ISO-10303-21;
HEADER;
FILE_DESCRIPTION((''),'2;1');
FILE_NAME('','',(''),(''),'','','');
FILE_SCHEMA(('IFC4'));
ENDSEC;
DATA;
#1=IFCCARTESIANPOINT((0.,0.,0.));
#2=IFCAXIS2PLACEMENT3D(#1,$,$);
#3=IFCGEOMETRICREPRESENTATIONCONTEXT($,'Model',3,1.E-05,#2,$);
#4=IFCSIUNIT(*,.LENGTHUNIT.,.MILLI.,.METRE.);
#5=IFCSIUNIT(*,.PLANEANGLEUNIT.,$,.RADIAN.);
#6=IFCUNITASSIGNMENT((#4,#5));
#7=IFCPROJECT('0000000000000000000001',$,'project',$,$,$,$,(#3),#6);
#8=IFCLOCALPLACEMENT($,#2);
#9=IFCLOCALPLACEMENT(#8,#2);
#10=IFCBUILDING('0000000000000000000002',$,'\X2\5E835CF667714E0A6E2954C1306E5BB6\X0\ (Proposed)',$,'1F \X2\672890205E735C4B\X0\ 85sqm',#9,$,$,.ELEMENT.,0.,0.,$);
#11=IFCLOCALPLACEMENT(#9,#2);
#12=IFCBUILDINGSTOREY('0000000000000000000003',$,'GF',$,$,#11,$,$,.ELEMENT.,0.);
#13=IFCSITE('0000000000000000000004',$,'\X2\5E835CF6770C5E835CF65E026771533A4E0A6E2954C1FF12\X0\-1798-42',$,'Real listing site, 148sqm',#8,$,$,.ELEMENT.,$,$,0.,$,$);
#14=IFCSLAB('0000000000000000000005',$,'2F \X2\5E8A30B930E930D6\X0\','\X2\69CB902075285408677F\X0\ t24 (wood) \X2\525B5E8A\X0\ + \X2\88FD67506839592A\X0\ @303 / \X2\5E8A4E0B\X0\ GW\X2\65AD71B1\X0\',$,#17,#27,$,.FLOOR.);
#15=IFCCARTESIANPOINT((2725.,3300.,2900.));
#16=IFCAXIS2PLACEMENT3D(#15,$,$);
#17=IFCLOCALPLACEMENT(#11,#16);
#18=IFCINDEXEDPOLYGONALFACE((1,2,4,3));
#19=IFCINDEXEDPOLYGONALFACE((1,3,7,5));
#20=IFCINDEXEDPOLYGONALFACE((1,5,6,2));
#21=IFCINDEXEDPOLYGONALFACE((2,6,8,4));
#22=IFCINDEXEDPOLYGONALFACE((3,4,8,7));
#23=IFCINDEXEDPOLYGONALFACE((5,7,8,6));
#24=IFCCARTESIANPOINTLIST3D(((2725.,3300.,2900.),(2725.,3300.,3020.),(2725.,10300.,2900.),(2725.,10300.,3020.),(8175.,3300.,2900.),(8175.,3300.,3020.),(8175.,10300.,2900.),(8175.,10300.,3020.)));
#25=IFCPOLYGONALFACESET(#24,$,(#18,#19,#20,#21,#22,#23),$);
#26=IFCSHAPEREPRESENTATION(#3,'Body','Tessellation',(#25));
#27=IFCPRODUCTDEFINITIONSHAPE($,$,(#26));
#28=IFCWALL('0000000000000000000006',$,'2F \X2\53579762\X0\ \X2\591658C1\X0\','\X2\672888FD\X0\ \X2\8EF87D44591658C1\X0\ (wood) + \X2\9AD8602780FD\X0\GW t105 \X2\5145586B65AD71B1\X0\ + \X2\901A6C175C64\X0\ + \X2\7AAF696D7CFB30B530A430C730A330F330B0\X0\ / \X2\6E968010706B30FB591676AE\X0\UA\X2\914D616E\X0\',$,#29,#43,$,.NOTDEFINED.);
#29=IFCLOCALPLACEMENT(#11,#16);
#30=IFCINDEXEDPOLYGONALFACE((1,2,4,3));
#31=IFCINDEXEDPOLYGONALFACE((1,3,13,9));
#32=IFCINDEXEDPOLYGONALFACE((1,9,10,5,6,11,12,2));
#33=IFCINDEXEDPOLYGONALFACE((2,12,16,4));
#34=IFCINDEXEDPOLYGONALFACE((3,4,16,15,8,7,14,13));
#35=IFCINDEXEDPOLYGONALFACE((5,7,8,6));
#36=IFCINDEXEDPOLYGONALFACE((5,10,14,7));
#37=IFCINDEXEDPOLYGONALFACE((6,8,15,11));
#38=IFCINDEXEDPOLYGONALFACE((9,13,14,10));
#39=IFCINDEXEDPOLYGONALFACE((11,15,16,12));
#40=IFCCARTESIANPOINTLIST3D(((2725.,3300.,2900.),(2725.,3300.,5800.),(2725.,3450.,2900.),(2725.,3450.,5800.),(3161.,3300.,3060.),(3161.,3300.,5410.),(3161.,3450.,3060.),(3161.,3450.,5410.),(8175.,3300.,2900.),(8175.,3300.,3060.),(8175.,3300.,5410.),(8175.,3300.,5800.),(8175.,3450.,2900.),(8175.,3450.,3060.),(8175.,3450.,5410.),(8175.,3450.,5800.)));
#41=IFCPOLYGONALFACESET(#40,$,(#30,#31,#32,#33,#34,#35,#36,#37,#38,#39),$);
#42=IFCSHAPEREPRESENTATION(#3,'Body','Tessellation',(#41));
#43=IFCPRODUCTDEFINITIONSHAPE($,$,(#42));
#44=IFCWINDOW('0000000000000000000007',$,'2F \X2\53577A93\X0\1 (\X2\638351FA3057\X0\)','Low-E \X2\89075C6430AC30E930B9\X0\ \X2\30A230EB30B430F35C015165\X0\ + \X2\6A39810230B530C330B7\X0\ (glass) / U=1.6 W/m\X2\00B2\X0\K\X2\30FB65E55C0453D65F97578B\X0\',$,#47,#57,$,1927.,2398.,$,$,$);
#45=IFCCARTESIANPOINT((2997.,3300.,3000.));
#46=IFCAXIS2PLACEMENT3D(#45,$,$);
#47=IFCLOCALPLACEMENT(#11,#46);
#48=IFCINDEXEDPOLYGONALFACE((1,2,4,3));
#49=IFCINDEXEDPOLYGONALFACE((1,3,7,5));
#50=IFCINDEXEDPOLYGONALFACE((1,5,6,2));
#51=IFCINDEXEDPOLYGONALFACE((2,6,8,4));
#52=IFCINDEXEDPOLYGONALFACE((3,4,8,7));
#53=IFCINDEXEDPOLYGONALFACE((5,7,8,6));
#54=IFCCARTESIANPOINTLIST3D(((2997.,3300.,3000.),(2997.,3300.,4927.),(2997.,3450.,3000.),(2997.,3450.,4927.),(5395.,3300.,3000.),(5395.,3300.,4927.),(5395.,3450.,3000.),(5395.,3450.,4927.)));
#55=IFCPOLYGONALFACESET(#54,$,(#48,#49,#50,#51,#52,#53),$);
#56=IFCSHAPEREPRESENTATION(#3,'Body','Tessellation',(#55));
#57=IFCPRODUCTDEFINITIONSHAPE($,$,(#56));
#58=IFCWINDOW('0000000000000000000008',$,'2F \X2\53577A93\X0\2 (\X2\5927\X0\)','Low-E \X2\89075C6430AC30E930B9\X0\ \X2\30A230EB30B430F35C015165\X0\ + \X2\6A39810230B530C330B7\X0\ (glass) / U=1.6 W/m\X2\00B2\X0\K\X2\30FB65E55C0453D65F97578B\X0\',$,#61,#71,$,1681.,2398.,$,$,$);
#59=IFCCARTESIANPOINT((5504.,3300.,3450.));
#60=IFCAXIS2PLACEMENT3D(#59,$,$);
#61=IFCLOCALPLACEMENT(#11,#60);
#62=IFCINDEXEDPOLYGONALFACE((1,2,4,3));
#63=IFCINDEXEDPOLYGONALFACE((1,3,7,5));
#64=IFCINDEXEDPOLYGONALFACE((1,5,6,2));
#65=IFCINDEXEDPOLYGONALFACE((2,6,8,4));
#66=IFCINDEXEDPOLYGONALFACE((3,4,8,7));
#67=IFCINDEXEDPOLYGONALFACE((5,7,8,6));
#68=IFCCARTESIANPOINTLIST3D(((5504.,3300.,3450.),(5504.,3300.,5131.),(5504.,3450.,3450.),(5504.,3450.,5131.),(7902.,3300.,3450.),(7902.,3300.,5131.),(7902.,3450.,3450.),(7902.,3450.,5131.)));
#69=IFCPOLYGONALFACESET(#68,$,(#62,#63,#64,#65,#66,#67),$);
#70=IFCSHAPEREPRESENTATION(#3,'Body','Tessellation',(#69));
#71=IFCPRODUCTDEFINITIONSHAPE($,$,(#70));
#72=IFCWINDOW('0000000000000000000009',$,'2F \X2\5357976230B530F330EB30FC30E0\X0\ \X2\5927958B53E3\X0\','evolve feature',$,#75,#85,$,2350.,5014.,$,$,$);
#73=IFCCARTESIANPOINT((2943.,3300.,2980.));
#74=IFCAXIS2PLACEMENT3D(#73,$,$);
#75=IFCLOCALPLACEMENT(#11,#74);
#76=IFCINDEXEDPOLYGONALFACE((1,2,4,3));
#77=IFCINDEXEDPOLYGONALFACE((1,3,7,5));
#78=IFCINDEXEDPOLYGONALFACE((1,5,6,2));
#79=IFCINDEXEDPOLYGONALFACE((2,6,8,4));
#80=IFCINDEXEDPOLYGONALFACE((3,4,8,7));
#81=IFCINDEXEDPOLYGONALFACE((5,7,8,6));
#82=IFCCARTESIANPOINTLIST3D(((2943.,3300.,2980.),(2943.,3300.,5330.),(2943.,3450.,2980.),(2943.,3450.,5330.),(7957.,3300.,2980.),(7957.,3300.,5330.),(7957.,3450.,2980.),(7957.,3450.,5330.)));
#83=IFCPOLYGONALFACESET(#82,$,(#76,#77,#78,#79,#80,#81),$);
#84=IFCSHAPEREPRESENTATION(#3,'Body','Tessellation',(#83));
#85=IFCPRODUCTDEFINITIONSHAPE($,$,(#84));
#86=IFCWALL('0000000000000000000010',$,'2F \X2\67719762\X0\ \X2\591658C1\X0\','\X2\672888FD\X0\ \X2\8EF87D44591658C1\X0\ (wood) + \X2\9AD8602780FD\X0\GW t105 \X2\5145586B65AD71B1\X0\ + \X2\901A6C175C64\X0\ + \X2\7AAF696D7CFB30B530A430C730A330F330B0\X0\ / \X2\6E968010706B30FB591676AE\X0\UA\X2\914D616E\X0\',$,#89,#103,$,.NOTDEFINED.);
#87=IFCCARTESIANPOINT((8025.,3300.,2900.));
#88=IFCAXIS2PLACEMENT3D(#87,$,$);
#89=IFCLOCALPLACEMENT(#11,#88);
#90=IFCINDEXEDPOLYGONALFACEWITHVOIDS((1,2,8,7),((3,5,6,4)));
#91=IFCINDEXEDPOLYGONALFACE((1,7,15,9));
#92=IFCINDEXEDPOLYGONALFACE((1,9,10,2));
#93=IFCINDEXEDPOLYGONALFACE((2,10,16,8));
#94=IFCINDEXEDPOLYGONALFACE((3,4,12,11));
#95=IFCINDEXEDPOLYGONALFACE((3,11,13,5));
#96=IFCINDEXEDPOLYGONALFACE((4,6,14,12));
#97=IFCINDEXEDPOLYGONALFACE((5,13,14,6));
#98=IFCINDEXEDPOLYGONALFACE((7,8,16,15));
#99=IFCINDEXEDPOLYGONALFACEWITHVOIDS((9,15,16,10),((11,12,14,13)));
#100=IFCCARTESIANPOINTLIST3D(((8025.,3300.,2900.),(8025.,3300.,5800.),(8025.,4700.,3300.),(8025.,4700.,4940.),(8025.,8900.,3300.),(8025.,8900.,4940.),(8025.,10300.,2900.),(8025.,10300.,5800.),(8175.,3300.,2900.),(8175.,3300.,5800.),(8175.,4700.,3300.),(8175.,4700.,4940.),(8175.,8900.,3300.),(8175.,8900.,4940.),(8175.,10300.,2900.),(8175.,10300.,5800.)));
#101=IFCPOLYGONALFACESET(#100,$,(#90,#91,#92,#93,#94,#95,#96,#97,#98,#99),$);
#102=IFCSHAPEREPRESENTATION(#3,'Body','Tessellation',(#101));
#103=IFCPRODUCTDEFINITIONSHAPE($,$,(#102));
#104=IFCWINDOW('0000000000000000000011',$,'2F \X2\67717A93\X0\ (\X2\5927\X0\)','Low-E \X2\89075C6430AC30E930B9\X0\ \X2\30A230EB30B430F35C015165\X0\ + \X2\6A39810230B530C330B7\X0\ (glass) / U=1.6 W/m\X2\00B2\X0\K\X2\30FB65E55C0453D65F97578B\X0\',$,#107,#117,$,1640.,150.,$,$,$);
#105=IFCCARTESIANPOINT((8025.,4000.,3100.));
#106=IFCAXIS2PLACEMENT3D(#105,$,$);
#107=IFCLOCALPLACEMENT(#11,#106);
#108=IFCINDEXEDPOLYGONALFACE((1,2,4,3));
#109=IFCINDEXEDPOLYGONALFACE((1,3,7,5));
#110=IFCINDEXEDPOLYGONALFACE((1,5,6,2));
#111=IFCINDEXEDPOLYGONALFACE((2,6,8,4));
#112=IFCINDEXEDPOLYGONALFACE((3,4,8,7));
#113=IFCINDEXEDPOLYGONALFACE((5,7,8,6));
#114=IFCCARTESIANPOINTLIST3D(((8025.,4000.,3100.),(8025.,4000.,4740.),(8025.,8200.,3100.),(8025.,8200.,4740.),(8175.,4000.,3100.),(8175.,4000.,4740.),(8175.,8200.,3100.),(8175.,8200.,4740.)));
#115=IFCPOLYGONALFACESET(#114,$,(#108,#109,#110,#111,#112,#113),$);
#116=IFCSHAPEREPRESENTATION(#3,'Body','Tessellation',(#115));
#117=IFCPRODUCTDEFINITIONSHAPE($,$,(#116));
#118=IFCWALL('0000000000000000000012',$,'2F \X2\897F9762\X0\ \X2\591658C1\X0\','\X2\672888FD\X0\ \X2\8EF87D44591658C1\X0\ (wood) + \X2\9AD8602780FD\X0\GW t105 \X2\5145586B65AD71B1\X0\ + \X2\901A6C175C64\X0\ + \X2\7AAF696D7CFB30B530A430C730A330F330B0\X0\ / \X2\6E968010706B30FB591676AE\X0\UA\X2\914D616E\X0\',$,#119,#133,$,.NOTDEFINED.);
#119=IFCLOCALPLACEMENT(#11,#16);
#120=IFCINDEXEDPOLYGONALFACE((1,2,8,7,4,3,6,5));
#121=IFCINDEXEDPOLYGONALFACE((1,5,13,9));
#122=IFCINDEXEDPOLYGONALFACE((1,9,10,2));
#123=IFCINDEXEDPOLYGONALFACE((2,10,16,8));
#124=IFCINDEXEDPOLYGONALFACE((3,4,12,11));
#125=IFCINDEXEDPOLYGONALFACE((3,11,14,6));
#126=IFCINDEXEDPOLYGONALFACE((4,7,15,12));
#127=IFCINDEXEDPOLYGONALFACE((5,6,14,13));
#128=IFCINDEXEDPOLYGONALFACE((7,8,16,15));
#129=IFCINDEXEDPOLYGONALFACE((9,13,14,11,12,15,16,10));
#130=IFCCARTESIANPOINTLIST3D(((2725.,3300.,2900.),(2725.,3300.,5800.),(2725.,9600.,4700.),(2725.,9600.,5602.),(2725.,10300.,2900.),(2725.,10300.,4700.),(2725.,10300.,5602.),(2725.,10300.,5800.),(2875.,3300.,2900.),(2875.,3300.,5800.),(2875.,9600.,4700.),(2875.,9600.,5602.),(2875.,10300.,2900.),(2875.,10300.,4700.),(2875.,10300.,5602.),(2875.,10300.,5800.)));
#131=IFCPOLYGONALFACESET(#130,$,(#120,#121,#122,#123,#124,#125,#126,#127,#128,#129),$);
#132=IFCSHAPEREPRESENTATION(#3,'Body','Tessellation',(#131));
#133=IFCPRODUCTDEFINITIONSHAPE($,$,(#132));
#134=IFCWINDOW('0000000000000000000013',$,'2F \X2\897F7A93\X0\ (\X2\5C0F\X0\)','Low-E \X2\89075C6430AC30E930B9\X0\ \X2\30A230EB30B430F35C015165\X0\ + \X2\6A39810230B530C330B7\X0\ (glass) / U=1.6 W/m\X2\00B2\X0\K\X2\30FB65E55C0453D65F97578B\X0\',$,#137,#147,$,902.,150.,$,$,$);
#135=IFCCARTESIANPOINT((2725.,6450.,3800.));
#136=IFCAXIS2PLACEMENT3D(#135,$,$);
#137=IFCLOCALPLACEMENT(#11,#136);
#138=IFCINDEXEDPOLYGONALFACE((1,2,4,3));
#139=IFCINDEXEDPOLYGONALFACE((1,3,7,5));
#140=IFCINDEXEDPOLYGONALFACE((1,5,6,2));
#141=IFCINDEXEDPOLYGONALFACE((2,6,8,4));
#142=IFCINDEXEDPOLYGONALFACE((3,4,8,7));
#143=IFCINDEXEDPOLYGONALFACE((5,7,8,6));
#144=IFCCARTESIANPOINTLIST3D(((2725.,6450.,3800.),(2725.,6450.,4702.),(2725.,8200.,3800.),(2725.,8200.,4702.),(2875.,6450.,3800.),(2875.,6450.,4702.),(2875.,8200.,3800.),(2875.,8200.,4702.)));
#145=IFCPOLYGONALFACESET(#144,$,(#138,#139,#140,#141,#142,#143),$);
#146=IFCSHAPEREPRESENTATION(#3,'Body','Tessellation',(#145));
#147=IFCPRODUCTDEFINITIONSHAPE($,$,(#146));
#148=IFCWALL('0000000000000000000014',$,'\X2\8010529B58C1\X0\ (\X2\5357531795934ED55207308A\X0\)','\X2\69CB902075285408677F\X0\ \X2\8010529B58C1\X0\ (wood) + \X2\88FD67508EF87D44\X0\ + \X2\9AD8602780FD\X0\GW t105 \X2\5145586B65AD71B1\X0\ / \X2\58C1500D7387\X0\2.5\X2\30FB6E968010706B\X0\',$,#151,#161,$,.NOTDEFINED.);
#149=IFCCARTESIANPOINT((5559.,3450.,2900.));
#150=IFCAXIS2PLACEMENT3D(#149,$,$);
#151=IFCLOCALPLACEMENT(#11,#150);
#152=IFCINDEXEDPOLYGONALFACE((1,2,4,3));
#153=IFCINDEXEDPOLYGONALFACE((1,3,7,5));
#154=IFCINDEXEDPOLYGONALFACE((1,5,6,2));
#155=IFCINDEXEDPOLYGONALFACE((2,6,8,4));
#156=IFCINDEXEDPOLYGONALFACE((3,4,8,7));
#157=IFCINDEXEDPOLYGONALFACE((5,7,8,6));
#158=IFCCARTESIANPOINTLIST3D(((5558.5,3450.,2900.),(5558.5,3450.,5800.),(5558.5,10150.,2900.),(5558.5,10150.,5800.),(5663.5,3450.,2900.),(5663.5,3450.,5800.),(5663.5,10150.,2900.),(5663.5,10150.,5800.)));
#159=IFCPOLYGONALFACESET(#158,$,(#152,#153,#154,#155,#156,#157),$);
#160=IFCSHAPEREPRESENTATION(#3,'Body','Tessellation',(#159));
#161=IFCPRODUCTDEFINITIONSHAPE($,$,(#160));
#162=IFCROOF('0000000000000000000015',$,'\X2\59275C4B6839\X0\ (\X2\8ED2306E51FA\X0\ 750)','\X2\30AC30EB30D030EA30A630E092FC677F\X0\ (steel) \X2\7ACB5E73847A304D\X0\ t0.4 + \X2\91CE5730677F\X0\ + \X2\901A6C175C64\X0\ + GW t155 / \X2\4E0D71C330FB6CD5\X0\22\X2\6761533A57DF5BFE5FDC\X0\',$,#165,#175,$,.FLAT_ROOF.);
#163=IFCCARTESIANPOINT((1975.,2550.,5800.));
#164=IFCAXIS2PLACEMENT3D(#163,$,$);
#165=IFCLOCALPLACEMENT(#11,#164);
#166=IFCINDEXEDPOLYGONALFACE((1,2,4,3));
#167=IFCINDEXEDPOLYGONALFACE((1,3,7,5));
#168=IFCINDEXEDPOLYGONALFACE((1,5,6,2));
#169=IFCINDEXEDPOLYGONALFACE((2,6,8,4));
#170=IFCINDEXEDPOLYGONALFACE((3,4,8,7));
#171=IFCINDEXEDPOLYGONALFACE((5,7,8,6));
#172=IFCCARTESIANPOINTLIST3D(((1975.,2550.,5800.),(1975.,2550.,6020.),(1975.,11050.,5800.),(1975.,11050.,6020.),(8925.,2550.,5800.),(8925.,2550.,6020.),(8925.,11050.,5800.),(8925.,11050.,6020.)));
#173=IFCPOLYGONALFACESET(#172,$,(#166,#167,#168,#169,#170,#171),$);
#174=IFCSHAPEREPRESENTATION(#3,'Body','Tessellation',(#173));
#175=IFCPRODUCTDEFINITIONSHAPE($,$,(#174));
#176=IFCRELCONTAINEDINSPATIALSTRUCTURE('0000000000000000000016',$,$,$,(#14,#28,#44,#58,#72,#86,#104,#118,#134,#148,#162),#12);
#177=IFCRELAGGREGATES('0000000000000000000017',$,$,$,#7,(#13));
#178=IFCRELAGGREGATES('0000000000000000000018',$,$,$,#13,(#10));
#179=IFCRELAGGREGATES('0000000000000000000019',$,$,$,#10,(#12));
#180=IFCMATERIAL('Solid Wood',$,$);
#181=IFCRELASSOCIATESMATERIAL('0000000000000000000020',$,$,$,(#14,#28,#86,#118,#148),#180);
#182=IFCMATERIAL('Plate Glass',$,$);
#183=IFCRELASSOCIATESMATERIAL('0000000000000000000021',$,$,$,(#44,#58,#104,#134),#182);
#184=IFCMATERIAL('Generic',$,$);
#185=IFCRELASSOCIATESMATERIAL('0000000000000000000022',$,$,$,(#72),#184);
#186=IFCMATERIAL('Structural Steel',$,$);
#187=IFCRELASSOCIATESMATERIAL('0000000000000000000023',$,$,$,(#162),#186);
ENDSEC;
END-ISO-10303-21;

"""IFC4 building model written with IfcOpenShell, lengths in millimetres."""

from ifc_helpers import new_model, si_unit, frame, frame_2d, origin, place, context, project, spatial, rectangle, extrude, material, element, fill, save


model = new_model("IFC4")

# Units and contexts
model_context = context("Model", 3, precision=1e-05, world=origin())
ifc_project = project(units=[si_unit("LENGTHUNIT", "METRE", prefix="MILLI"), si_unit("PLANEANGLEUNIT", "RADIAN")], contexts=[model_context])

# Site, building, storey
site_placement = place(None, origin())
site = spatial("IfcSite", under=ifc_project, at=site_placement, Name="広島県広島市東区上温品２-1798-42", ObjectType="Real listing site, 148sqm", CompositionType="ELEMENT", RefElevation=0.0)
building_placement = place(site_placement, origin())
building = spatial("IfcBuilding", under=site, at=building_placement, Name="広島東上温品の家 (Proposed)", ObjectType="1F 木造平屋 85sqm", CompositionType="ELEMENT", ElevationOfRefHeight=0.0, ElevationOfTerrain=0.0)
storey_placement = place(building_placement, origin())
storey = spatial("IfcBuildingStorey", under=building, at=storey_placement, Name="GF", CompositionType="ELEMENT", Elevation=0.0)

# Slab
ifc_material_1 = material(Name="Solid Wood")
slab_placement = place(storey_placement, frame((2725.0, 3300.0, 2900.0)))
element("IfcSlab", 1, at=slab_placement, inside=storey, material=ifc_material_1, Name="2F 床スラブ", Description="構造用合板 t24 (wood) 剛床 + 製材根太 @303 / 床下 GW断熱", PredefinedType="FLOOR", context=model_context, shape_type="SweptSolid", body=[
    extrude(rectangle(XDim=5450.0, YDim=7000.0, at=frame_2d((2725.0, 3500.0))), frame((2725.0, 3300.0, 2900.0)), (0.0, 0.0, 1.0), 120.0),
])

# Wall, openings, windows
wall_1_placement = place(storey_placement, frame((2725.0, 3300.0, 2900.0)))
wall_1 = element("IfcWall", 2, at=wall_1_placement, inside=storey, material=ifc_material_1, Name="2F 南面 外壁", Description="木製 軸組外壁 (wood) + 高性能GW t105 充填断熱 + 通気層 + 窯業系サイディング / 準耐火・外皮UA配慮", PredefinedType="NOTDEFINED", context=model_context, shape_type="SweptSolid", body=[
    extrude(rectangle(XDim=5450.0, YDim=150.0, at=frame_2d((2725.0, 75.0))), frame((2725.0, 3300.0, 2900.0)), (0.0, 0.0, 1.0), 2900.0),
])
opening_1_placement = place(storey_placement, frame((2997.0, 3300.0, 3000.0)))
opening_1 = element("IfcOpeningElement", 3, at=opening_1_placement, cuts=wall_1, PredefinedType="NOTDEFINED", context=model_context, shape_type="SweptSolid", body=[
    extrude(rectangle(XDim=2398.0, YDim=150.0, at=frame_2d((1199.0, 75.0))), frame((2997.0, 3300.0, 3000.0)), (0.0, 0.0, 1.0), 1927.0),
])
opening_2_placement = place(storey_placement, frame((5504.0, 3300.0, 3450.0)))
opening_2 = element("IfcOpeningElement", 4, at=opening_2_placement, cuts=wall_1, PredefinedType="NOTDEFINED", context=model_context, shape_type="SweptSolid", body=[
    extrude(rectangle(XDim=2398.0, YDim=150.0, at=frame_2d((1199.0, 75.0))), frame((5504.0, 3300.0, 3450.0)), (0.0, 0.0, 1.0), 1681.0),
])
opening_3_placement = place(storey_placement, frame((2943.0, 3300.0, 2980.0)))
opening_3 = element("IfcOpeningElement", 5, at=opening_3_placement, cuts=wall_1, PredefinedType="NOTDEFINED", context=model_context, shape_type="SweptSolid", body=[
    extrude(rectangle(XDim=5014.0, YDim=150.0, at=frame_2d((2507.0, 75.0))), frame((2943.0, 3300.0, 2980.0)), (0.0, 0.0, 1.0), 2350.0),
])
ifc_material_2 = material(Name="Plate Glass")
window_1_placement = place(storey_placement, frame((2997.0, 3300.0, 3000.0)))
window_1 = element("IfcWindow", 6, at=window_1_placement, inside=storey, material=ifc_material_2, Name="2F 南窓1 (掃出し)", Description="Low-E 複層ガラス アルゴン封入 + 樹脂サッシ (glass) / U=1.6 W/m²K・日射取得型", OverallHeight=1927.0, OverallWidth=2398.0, context=model_context, shape_type="SweptSolid", body=[
    extrude(rectangle(XDim=2398.0, YDim=150.0, at=frame_2d((1199.0, 75.0))), frame((2997.0, 3300.0, 3000.0)), (0.0, 0.0, 1.0), 1927.0),
])
fill(opening_1, window_1)
window_2_placement = place(storey_placement, frame((5504.0, 3300.0, 3450.0)))
window_2 = element("IfcWindow", 7, at=window_2_placement, inside=storey, material=ifc_material_2, Name="2F 南窓2 (大)", Description="Low-E 複層ガラス アルゴン封入 + 樹脂サッシ (glass) / U=1.6 W/m²K・日射取得型", OverallHeight=1681.0, OverallWidth=2398.0, context=model_context, shape_type="SweptSolid", body=[
    extrude(rectangle(XDim=2398.0, YDim=150.0, at=frame_2d((1199.0, 75.0))), frame((5504.0, 3300.0, 3450.0)), (0.0, 0.0, 1.0), 1681.0),
])
fill(opening_2, window_2)
ifc_material_3 = material(Name="Generic")
window_3_placement = place(storey_placement, frame((2943.0, 3300.0, 2980.0)))
window_3 = element("IfcWindow", 8, at=window_3_placement, inside=storey, material=ifc_material_3, Name="2F 南面サンルーム 大開口", Description="evolve feature", OverallHeight=2350.0, OverallWidth=5014.0, context=model_context, shape_type="SweptSolid", body=[
    extrude(rectangle(XDim=5014.0, YDim=150.0, at=frame_2d((2507.0, 75.0))), frame((2943.0, 3300.0, 2980.0)), (0.0, 0.0, 1.0), 2350.0),
])
fill(opening_3, window_3)

# Walls, openings, windows
wall_2_placement = place(storey_placement, frame((8025.0, 3300.0, 2900.0)))
wall_2 = element("IfcWall", 9, at=wall_2_placement, inside=storey, material=ifc_material_1, Name="2F 東面 外壁", Description="木製 軸組外壁 (wood) + 高性能GW t105 充填断熱 + 通気層 + 窯業系サイディング / 準耐火・外皮UA配慮", PredefinedType="NOTDEFINED", context=model_context, shape_type="SweptSolid", body=[
    extrude(rectangle(XDim=150.0, YDim=7000.0, at=frame_2d((75.0, 3500.0))), frame((8025.0, 3300.0, 2900.0)), (0.0, 0.0, 1.0), 2900.0),
])
opening_4_placement = place(storey_placement, frame((8025.0, 4000.0, 3100.0)))
opening_4 = element("IfcOpeningElement", 10, at=opening_4_placement, cuts=wall_2, PredefinedType="NOTDEFINED", context=model_context, shape_type="SweptSolid", body=[
    extrude(rectangle(XDim=150.0, YDim=4200.0, at=frame_2d((75.0, 2100.0))), frame((8025.0, 4000.0, 3100.0)), (0.0, 0.0, 1.0), 1640.0),
])
window_4_placement = place(storey_placement, frame((8025.0, 4000.0, 3100.0)))
window_4 = element("IfcWindow", 11, at=window_4_placement, inside=storey, material=ifc_material_2, Name="2F 東窓 (大)", Description="Low-E 複層ガラス アルゴン封入 + 樹脂サッシ (glass) / U=1.6 W/m²K・日射取得型", OverallHeight=1640.0, OverallWidth=150.0, context=model_context, shape_type="SweptSolid", body=[
    extrude(rectangle(XDim=150.0, YDim=4200.0, at=frame_2d((75.0, 2100.0))), frame((8025.0, 4000.0, 3100.0)), (0.0, 0.0, 1.0), 1640.0),
])
fill(opening_4, window_4)
wall_3_placement = place(storey_placement, frame((2725.0, 3300.0, 2900.0)))
wall_3 = element("IfcWall", 12, at=wall_3_placement, inside=storey, material=ifc_material_1, Name="2F 西面 外壁", Description="木製 軸組外壁 (wood) + 高性能GW t105 充填断熱 + 通気層 + 窯業系サイディング / 準耐火・外皮UA配慮", PredefinedType="NOTDEFINED", context=model_context, shape_type="SweptSolid", body=[
    extrude(rectangle(XDim=150.0, YDim=7000.0, at=frame_2d((75.0, 3500.0))), frame((2725.0, 3300.0, 2900.0)), (0.0, 0.0, 1.0), 2900.0),
])
opening_5_placement = place(storey_placement, frame((2725.0, 6450.0, 3800.0)))
opening_5 = element("IfcOpeningElement", 13, at=opening_5_placement, cuts=wall_3, PredefinedType="NOTDEFINED", context=model_context, shape_type="SweptSolid", body=[
    extrude(rectangle(XDim=150.0, YDim=1750.0, at=frame_2d((75.0, 875.0))), frame((2725.0, 6450.0, 3800.0)), (0.0, 0.0, 1.0), 902.0),
])
window_5_placement = place(storey_placement, frame((2725.0, 6450.0, 3800.0)))
window_5 = element("IfcWindow", 14, at=window_5_placement, inside=storey, material=ifc_material_2, Name="2F 西窓 (小)", Description="Low-E 複層ガラス アルゴン封入 + 樹脂サッシ (glass) / U=1.6 W/m²K・日射取得型", OverallHeight=902.0, OverallWidth=150.0, context=model_context, shape_type="SweptSolid", body=[
    extrude(rectangle(XDim=150.0, YDim=1750.0, at=frame_2d((75.0, 875.0))), frame((2725.0, 6450.0, 3800.0)), (0.0, 0.0, 1.0), 902.0),
])
fill(opening_5, window_5)

# Wall
wall_4_placement = place(storey_placement, frame((5559.0, 3450.0, 2900.0)))
element("IfcWall", 15, at=wall_4_placement, inside=storey, material=ifc_material_1, Name="耐力壁 (南北間仕切り)", Description="構造用合板 耐力壁 (wood) + 製材軸組 + 高性能GW t105 充填断熱 / 壁倍率2.5・準耐火", PredefinedType="NOTDEFINED", context=model_context, shape_type="SweptSolid", body=[
    extrude(rectangle(XDim=105.0, YDim=6700.0, at=frame_2d((52.0, 3350.0))), frame((5559.0, 3450.0, 2900.0)), (0.0, 0.0, 1.0), 2900.0),
])

# Roof
ifc_material_4 = material(Name="Structural Steel")
roof_1_placement = place(storey_placement, frame((1975.0, 2550.0, 5800.0)))
element("IfcRoof", 16, at=roof_1_placement, inside=storey, material=ifc_material_4, Name="大屋根 (軒の出 750)", Description="ガルバリウム鋼板 (steel) 立平葺き t0.4 + 野地板 + 通気層 + GW t155 / 不燃・法22条区域対応", PredefinedType="FLAT_ROOF", context=model_context, shape_type="SweptSolid", body=[
    extrude(rectangle(XDim=6950.0, YDim=8500.0, at=frame_2d((3475.0, 4250.0))), frame((1975.0, 2550.0, 5800.0)), (0.0, 0.0, 1.0), 220.0),
])

save(model, "model.ifc")
